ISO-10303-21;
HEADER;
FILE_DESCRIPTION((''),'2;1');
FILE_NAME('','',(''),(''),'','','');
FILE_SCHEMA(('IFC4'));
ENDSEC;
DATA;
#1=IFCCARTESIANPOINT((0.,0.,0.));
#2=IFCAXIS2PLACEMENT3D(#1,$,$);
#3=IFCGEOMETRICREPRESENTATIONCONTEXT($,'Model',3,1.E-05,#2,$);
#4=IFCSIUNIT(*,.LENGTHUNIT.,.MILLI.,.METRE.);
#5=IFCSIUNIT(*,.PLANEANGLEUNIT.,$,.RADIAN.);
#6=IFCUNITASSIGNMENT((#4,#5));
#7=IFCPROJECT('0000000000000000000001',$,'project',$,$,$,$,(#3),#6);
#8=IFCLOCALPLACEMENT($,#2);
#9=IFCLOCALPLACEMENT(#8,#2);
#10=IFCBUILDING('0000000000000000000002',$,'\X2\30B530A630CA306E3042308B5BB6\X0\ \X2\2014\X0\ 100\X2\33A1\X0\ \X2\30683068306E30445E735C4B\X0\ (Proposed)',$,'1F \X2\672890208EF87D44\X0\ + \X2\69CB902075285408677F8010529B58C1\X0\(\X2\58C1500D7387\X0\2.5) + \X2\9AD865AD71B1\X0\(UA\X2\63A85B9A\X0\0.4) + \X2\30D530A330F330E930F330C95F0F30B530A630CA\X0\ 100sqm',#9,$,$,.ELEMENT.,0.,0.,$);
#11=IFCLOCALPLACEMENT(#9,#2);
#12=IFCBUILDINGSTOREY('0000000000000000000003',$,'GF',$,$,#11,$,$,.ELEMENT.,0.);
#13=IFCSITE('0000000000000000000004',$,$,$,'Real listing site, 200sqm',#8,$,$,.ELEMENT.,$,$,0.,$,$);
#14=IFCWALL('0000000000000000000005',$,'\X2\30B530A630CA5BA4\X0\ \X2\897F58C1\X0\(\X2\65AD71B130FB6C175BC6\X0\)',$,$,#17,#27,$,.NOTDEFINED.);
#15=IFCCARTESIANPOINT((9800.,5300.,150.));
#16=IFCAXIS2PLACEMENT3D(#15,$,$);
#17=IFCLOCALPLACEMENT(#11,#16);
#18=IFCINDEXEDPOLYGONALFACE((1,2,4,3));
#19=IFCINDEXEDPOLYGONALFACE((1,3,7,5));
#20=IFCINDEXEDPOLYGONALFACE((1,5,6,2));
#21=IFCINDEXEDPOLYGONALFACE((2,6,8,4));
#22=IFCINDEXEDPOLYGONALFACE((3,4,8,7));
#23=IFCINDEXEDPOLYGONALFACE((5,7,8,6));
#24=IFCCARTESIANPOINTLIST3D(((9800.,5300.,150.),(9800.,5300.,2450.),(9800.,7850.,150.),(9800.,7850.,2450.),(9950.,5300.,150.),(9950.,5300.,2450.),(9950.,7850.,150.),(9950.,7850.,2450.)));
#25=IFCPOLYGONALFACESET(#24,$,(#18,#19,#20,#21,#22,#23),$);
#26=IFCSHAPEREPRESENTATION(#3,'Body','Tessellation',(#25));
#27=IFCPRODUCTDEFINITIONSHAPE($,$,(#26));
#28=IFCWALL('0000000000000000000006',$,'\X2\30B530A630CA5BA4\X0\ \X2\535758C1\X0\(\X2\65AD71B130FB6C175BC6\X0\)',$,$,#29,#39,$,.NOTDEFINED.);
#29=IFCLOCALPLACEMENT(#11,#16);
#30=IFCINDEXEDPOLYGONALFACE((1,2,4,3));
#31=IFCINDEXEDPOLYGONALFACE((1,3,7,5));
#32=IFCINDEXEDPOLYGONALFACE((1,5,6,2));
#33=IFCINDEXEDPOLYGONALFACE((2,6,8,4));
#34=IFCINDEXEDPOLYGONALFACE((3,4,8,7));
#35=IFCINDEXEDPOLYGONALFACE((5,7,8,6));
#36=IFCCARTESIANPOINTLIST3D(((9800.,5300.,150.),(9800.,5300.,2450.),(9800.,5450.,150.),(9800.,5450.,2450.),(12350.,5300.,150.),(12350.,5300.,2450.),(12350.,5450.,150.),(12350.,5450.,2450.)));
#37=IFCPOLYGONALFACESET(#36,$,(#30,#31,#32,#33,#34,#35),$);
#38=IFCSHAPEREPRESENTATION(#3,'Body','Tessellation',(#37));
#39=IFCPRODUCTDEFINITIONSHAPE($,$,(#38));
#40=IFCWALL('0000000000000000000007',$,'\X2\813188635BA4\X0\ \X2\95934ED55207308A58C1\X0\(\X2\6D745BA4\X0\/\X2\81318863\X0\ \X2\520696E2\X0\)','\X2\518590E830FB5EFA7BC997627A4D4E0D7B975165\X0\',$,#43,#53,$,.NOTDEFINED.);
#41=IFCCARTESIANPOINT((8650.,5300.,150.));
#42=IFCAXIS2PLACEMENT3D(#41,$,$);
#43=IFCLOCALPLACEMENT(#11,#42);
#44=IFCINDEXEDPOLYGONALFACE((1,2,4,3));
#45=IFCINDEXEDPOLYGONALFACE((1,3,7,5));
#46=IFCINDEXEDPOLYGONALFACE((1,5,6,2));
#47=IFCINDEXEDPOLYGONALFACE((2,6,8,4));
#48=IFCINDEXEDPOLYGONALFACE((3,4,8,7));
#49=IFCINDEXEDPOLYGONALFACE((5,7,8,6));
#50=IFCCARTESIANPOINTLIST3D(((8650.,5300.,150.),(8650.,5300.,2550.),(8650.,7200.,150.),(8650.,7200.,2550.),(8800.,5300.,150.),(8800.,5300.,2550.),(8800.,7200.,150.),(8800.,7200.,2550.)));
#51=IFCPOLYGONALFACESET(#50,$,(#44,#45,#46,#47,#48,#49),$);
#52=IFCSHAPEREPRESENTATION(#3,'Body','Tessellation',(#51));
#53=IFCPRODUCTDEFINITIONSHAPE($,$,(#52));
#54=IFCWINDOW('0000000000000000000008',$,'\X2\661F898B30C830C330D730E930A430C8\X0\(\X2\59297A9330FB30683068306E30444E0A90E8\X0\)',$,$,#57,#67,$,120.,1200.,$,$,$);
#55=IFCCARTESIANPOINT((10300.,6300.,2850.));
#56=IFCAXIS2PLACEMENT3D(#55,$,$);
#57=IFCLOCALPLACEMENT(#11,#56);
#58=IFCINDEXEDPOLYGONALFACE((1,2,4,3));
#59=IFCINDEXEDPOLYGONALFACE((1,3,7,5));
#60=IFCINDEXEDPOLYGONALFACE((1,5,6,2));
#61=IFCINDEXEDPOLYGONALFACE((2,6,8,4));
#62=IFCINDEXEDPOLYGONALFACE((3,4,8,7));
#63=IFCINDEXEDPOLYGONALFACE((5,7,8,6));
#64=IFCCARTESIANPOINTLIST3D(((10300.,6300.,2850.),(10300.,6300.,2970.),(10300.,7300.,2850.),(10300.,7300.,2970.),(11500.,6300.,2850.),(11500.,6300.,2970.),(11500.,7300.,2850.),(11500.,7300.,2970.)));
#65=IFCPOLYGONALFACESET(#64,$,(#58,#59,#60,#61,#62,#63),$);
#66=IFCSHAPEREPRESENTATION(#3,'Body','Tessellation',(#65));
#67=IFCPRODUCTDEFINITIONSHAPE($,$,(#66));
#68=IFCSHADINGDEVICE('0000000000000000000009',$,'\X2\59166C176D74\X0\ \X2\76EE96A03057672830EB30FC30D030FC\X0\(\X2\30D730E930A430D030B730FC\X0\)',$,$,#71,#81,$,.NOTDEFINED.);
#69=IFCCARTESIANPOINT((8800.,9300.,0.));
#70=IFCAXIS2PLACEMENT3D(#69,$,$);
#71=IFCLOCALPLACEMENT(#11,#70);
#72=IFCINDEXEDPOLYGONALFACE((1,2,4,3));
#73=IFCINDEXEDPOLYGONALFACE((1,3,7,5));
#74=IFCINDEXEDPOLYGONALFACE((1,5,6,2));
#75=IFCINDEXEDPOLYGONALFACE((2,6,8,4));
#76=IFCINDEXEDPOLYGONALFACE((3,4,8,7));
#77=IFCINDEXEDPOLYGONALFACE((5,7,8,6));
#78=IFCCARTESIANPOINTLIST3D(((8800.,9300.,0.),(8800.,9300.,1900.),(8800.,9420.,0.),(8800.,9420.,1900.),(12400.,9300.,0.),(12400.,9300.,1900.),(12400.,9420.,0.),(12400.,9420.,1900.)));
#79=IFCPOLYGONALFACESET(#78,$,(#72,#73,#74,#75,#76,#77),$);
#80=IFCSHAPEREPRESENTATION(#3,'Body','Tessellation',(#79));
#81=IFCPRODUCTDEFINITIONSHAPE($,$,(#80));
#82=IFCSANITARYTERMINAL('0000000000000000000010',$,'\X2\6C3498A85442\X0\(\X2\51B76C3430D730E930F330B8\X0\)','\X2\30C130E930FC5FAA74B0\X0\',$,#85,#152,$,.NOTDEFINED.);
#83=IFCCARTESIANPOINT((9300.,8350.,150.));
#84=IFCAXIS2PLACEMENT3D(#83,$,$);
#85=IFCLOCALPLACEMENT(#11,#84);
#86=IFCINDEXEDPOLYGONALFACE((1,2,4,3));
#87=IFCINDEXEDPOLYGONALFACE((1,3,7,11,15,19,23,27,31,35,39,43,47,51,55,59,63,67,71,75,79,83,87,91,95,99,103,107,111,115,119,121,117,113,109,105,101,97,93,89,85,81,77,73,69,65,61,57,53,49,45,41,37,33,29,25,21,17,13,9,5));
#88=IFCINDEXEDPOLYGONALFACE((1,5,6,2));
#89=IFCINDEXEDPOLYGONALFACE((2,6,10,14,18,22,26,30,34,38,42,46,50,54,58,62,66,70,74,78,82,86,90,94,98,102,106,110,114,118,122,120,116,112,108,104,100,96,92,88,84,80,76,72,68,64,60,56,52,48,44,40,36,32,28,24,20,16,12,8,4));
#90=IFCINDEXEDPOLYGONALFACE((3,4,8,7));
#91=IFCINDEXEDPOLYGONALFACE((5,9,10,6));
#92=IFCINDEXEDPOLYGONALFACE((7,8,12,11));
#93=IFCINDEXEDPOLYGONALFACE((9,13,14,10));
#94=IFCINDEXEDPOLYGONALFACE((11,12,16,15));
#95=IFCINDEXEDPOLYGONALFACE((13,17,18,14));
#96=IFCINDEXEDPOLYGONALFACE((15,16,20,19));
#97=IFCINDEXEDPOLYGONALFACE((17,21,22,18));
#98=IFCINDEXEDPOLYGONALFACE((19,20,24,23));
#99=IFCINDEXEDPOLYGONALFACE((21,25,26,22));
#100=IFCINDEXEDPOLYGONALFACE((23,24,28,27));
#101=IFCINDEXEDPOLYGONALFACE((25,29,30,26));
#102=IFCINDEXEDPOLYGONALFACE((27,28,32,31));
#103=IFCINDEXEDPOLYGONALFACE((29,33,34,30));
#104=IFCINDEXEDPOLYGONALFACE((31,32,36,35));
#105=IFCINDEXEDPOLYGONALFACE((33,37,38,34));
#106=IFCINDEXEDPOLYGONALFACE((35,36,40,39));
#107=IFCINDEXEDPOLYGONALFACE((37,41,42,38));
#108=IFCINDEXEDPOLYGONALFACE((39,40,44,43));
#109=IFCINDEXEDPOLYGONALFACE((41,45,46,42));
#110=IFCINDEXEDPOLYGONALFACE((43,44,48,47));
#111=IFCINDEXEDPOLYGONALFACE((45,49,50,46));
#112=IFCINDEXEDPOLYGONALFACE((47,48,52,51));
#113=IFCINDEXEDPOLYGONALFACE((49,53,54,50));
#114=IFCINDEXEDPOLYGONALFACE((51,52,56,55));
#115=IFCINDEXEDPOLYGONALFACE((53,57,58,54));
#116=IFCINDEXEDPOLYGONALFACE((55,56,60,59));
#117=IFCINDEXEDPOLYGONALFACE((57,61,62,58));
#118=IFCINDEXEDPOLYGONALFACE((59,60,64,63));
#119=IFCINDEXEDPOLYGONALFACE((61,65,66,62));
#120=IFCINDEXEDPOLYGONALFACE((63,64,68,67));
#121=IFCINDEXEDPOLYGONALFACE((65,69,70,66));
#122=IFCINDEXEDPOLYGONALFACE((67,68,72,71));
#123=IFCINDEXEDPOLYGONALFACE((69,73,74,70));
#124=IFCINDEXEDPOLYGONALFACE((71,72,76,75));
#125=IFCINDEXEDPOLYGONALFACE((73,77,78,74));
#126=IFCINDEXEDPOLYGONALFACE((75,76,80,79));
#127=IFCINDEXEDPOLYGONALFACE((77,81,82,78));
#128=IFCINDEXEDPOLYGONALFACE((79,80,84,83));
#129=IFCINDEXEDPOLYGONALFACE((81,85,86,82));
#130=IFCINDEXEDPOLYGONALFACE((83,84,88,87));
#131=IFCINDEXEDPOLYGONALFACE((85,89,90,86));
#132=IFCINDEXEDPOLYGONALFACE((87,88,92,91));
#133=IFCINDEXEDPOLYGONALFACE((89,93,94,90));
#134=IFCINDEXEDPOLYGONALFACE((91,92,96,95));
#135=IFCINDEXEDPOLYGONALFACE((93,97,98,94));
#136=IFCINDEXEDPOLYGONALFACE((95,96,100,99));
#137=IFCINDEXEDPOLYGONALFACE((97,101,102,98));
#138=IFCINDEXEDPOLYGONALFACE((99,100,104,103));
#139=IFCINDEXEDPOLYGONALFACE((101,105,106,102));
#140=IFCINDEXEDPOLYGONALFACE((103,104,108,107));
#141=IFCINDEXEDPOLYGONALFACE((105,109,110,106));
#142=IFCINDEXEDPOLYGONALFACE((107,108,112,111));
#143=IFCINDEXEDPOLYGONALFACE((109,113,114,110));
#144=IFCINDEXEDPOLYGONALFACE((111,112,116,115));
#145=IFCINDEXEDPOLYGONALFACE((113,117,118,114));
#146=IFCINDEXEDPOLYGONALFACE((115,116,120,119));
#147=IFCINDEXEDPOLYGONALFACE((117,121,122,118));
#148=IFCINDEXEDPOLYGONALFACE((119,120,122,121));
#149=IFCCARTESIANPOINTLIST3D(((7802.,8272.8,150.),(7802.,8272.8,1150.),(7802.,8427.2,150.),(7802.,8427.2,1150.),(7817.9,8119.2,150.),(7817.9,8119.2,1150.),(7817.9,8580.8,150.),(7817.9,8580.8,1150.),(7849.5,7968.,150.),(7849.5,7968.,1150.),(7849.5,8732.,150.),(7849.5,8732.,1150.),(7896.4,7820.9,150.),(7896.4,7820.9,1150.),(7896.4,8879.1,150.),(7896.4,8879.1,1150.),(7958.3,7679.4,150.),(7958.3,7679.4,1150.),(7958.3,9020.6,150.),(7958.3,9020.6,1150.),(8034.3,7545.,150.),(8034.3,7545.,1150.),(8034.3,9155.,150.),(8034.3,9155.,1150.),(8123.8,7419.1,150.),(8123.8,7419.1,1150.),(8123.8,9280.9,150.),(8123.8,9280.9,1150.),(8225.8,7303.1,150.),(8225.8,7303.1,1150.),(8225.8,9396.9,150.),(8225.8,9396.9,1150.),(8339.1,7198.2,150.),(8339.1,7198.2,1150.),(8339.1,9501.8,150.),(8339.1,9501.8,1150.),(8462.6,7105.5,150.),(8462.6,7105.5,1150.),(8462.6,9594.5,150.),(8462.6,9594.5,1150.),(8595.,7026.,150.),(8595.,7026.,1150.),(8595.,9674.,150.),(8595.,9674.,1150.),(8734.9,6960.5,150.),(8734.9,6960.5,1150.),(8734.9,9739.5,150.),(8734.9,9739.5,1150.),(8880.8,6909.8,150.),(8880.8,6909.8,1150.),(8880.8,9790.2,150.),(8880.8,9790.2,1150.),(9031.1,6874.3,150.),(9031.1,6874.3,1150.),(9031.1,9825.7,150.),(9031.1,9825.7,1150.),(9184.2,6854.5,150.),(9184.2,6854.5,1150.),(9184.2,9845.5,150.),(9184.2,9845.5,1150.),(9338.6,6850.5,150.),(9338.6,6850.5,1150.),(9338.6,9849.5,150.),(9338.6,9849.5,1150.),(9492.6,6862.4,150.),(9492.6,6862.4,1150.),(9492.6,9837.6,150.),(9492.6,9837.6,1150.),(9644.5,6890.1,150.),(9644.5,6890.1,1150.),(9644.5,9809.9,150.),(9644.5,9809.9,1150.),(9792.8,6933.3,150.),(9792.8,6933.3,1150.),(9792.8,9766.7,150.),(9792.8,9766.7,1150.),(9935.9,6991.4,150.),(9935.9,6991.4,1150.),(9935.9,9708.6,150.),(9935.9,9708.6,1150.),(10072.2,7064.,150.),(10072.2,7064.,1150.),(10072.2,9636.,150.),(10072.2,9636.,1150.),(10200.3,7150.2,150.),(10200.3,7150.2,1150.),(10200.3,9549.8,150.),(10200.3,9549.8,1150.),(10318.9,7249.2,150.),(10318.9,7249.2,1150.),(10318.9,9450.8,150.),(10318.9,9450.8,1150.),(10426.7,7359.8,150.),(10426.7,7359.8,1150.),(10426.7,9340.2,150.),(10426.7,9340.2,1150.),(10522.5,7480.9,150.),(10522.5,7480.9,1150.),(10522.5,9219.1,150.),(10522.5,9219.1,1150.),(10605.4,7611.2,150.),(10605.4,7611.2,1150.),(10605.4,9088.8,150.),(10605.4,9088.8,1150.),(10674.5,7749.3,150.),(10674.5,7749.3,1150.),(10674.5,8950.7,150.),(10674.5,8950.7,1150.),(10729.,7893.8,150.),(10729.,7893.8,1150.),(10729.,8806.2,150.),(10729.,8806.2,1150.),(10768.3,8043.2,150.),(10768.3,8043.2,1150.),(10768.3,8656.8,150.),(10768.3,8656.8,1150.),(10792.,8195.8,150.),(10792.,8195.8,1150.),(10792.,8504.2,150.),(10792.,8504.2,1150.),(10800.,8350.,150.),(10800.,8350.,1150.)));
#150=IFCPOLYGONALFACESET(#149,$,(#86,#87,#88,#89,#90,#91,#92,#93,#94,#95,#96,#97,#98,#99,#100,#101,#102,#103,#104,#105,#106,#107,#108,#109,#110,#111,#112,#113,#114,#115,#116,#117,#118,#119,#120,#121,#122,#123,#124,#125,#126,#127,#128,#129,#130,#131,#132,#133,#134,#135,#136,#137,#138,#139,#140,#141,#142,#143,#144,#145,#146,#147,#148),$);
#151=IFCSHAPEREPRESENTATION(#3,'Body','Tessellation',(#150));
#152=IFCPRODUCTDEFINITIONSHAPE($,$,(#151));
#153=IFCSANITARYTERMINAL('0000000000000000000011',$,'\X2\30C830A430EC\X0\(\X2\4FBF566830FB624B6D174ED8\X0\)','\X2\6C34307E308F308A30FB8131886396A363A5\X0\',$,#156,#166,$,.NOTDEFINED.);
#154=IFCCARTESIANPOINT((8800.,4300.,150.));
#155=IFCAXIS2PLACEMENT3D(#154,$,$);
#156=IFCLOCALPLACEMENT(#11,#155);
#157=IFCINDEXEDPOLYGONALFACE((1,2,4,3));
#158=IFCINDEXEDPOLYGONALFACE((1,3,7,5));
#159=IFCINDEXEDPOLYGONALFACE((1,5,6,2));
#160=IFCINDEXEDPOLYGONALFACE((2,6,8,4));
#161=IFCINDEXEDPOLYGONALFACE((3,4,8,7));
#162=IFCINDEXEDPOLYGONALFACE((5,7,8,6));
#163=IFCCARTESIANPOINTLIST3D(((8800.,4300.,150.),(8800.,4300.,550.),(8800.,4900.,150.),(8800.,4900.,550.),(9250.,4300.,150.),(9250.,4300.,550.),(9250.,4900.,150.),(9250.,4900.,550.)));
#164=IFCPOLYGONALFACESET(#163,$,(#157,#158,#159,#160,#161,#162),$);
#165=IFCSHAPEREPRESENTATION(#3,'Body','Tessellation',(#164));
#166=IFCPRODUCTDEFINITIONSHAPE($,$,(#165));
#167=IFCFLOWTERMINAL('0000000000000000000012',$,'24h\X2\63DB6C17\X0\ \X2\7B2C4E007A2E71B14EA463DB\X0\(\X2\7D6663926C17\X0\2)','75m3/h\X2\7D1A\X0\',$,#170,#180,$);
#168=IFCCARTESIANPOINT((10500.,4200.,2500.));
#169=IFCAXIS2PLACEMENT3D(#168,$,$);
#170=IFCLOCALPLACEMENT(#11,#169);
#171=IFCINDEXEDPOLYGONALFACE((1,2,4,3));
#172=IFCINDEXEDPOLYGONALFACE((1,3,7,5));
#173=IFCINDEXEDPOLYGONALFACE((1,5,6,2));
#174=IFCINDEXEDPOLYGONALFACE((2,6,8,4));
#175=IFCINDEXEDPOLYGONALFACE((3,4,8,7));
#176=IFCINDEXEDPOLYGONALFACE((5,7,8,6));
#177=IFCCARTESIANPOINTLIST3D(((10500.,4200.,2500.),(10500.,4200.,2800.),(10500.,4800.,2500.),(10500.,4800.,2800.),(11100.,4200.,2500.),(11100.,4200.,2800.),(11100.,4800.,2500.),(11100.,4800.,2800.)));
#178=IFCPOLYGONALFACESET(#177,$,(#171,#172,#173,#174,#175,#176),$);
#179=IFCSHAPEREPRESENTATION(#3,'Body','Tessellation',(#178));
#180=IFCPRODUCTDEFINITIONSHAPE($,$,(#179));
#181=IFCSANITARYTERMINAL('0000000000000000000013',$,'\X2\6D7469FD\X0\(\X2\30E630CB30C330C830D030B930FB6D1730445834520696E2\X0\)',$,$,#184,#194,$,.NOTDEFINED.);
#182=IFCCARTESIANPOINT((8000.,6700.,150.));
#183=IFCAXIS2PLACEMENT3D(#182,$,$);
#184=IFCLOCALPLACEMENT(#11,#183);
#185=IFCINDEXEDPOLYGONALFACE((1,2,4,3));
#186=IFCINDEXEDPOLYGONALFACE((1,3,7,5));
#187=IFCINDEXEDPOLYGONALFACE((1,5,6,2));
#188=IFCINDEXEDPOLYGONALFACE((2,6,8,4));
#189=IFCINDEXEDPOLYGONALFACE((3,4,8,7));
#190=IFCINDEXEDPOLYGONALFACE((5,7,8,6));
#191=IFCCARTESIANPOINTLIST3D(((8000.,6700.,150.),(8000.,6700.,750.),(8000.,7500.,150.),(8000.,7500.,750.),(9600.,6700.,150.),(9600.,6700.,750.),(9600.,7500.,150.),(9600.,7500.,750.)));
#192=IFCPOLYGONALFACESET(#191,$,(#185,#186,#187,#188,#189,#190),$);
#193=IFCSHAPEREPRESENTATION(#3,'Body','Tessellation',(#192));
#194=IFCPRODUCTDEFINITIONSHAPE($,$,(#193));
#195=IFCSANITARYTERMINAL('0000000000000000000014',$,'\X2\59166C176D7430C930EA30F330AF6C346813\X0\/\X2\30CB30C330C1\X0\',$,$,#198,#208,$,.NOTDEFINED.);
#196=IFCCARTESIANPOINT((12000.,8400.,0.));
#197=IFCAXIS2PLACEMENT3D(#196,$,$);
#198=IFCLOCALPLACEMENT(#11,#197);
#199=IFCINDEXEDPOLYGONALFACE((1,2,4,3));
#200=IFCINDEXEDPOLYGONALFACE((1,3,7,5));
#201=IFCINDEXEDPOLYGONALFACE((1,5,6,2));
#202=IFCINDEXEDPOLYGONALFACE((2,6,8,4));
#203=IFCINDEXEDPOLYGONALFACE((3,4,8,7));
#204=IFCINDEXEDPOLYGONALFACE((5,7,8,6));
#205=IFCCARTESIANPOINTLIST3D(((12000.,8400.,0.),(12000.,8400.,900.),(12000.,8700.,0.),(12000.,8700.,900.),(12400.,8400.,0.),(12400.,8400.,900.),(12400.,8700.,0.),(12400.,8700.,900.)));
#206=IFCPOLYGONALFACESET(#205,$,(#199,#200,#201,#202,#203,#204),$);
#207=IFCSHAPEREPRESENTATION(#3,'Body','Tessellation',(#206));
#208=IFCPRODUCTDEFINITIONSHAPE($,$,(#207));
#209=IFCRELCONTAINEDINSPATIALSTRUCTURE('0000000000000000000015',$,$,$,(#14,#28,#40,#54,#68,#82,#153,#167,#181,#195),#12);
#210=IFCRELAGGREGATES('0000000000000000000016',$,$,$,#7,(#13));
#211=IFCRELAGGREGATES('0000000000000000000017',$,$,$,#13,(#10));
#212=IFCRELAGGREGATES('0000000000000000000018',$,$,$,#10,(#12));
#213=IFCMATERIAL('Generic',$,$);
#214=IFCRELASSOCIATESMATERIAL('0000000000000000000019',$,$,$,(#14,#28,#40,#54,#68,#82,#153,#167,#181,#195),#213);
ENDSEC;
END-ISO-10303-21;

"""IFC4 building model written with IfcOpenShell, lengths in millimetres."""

from ifc_helpers import new_model, si_unit, frame, frame_2d, origin, origin_2d, place, context, project, spatial, rectangle, circle, extrude, material, element, save


model = new_model("IFC4")

# Units and contexts
model_context = context("Model", 3, precision=1e-05, world=origin())
ifc_project = project(units=[si_unit("LENGTHUNIT", "METRE", prefix="MILLI"), si_unit("PLANEANGLEUNIT", "RADIAN")], contexts=[model_context])

# Site, building, storey
site_placement = place(None, origin())
site = spatial("IfcSite", under=ifc_project, at=site_placement, ObjectType="Real listing site, 200sqm", CompositionType="ELEMENT", RefElevation=0.0)
building_placement = place(site_placement, origin())
building = spatial("IfcBuilding", under=site, at=building_placement, Name="サウナのある家 — 100㎡ ととのい平屋 (Proposed)", ObjectType="1F 木造軸組 + 構造用合板耐力壁(壁倍率2.5) + 高断熱(UA推定0.4) + フィンランド式サウナ 100sqm", CompositionType="ELEMENT", ElevationOfRefHeight=0.0, ElevationOfTerrain=0.0)
storey_placement = place(building_placement, origin())
storey = spatial("IfcBuildingStorey", under=building, at=storey_placement, Name="GF", CompositionType="ELEMENT", Elevation=0.0)

# Shared definitions
ifc_material = material(Name="Generic")

# Walls
wall_1_placement = place(storey_placement, frame((9800.0, 5300.0, 150.0)))
element("IfcWall", 1, at=wall_1_placement, inside=storey, material=ifc_material, Name="サウナ室 西壁(断熱・気密)", PredefinedType="NOTDEFINED", context=model_context, shape_type="SweptSolid", body=[
    extrude(rectangle(XDim=150.0, YDim=2550.0, at=frame_2d((75.0, 1275.0))), frame((9800.0, 5300.0, 150.0)), (0.0, 0.0, 1.0), 2300.0),
])
wall_2_placement = place(storey_placement, frame((9800.0, 5300.0, 150.0)))
element("IfcWall", 2, at=wall_2_placement, inside=storey, material=ifc_material, Name="サウナ室 南壁(断熱・気密)", PredefinedType="NOTDEFINED", context=model_context, shape_type="SweptSolid", body=[
    extrude(rectangle(XDim=2550.0, YDim=150.0, at=frame_2d((1275.0, 75.0))), frame((9800.0, 5300.0, 150.0)), (0.0, 0.0, 1.0), 2300.0),
])
wall_3_placement = place(storey_placement, frame((8650.0, 5300.0, 150.0)))
element("IfcWall", 3, at=wall_3_placement, inside=storey, material=ifc_material, Name="脱衣室 間仕切り壁(浴室/脱衣 分離)", Description="内部・建築面積不算入", PredefinedType="NOTDEFINED", context=model_context, shape_type="SweptSolid", body=[
    extrude(rectangle(XDim=150.0, YDim=1900.0, at=frame_2d((75.0, 950.0))), frame((8650.0, 5300.0, 150.0)), (0.0, 0.0, 1.0), 2400.0),
])

# Window
window_1_placement = place(storey_placement, frame((10300.0, 6300.0, 2850.0)))
element("IfcWindow", 4, at=window_1_placement, inside=storey, material=ifc_material, Name="星見トップライト(天窓・ととのい上部)", OverallHeight=120.0, OverallWidth=1200.0, context=model_context, shape_type="SweptSolid", body=[
    extrude(rectangle(XDim=1200.0, YDim=1000.0, at=frame_2d((600.0, 500.0))), frame((10300.0, 6300.0, 2850.0)), (0.0, 0.0, 1.0), 120.0),
])

# Shading device
shading_device_placement = place(storey_placement, frame((8800.0, 9300.0, 0.0)))
element("IfcShadingDevice", 5, at=shading_device_placement, inside=storey, material=ifc_material, Name="外気浴 目隠し木ルーバー(プライバシー)", PredefinedType="NOTDEFINED", context=model_context, shape_type="SweptSolid", body=[
    extrude(rectangle(XDim=3600.0, YDim=120.0, at=frame_2d((1800.0, 60.0))), frame((8800.0, 9300.0, 0.0)), (0.0, 0.0, 1.0), 1900.0),
])

# Sanitary terminals
sanitary_terminal_1_placement = place(storey_placement, frame((9300.0, 8350.0, 150.0)))
element("IfcSanitaryTerminal", 6, at=sanitary_terminal_1_placement, inside=storey, material=ifc_material, Name="水風呂(冷水プランジ)", Description="チラー循環", PredefinedType="NOTDEFINED", context=model_context, shape_type="SweptSolid", body=[
    extrude(circle(Radius=1500.0, at=origin_2d()), frame((9300.0, 8350.0, 150.0)), (0.0, 0.0, 1.0), 1000.0),
])
sanitary_terminal_2_placement = place(storey_placement, frame((8800.0, 4300.0, 150.0)))
element("IfcSanitaryTerminal", 7, at=sanitary_terminal_2_placement, inside=storey, material=ifc_material, Name="トイレ(便器・手洗付)", Description="水まわり・脱衣隣接", PredefinedType="NOTDEFINED", context=model_context, shape_type="SweptSolid", body=[
    extrude(rectangle(XDim=450.0, YDim=600.0, at=frame_2d((225.0, 300.0))), frame((8800.0, 4300.0, 150.0)), (0.0, 0.0, 1.0), 400.0),
])

# Flow terminal
flow_terminal_placement = place(storey_placement, frame((10500.0, 4200.0, 2500.0)))
element("IfcFlowTerminal", 8, at=flow_terminal_placement, inside=storey, material=ifc_material, Name="24h換気 第一種熱交換(給排気2)", Description="75m3/h級", context=model_context, shape_type="SweptSolid", body=[
    extrude(rectangle(XDim=600.0, YDim=600.0, at=frame_2d((300.0, 300.0))), frame((10500.0, 4200.0, 2500.0)), (0.0, 0.0, 1.0), 300.0),
])

# Sanitary terminals
sanitary_terminal_3_placement = place(storey_placement, frame((8000.0, 6700.0, 150.0)))
element("IfcSanitaryTerminal", 9, at=sanitary_terminal_3_placement, inside=storey, material=ifc_material, Name="浴槽(ユニットバス・洗い場分離)", PredefinedType="NOTDEFINED", context=model_context, shape_type="SweptSolid", body=[
    extrude(rectangle(XDim=1600.0, YDim=800.0, at=frame_2d((800.0, 400.0))), frame((8000.0, 6700.0, 150.0)), (0.0, 0.0, 1.0), 600.0),
])
sanitary_terminal_4_placement = place(storey_placement, frame((12000.0, 8400.0, 0.0)))
element("IfcSanitaryTerminal", 10, at=sanitary_terminal_4_placement, inside=storey, material=ifc_material, Name="外気浴ドリンク水栓/ニッチ", PredefinedType="NOTDEFINED", context=model_context, shape_type="SweptSolid", body=[
    extrude(rectangle(XDim=400.0, YDim=300.0, at=frame_2d((200.0, 150.0))), frame((12000.0, 8400.0, 0.0)), (0.0, 0.0, 1.0), 900.0),
])

save(model, "model.ifc")
